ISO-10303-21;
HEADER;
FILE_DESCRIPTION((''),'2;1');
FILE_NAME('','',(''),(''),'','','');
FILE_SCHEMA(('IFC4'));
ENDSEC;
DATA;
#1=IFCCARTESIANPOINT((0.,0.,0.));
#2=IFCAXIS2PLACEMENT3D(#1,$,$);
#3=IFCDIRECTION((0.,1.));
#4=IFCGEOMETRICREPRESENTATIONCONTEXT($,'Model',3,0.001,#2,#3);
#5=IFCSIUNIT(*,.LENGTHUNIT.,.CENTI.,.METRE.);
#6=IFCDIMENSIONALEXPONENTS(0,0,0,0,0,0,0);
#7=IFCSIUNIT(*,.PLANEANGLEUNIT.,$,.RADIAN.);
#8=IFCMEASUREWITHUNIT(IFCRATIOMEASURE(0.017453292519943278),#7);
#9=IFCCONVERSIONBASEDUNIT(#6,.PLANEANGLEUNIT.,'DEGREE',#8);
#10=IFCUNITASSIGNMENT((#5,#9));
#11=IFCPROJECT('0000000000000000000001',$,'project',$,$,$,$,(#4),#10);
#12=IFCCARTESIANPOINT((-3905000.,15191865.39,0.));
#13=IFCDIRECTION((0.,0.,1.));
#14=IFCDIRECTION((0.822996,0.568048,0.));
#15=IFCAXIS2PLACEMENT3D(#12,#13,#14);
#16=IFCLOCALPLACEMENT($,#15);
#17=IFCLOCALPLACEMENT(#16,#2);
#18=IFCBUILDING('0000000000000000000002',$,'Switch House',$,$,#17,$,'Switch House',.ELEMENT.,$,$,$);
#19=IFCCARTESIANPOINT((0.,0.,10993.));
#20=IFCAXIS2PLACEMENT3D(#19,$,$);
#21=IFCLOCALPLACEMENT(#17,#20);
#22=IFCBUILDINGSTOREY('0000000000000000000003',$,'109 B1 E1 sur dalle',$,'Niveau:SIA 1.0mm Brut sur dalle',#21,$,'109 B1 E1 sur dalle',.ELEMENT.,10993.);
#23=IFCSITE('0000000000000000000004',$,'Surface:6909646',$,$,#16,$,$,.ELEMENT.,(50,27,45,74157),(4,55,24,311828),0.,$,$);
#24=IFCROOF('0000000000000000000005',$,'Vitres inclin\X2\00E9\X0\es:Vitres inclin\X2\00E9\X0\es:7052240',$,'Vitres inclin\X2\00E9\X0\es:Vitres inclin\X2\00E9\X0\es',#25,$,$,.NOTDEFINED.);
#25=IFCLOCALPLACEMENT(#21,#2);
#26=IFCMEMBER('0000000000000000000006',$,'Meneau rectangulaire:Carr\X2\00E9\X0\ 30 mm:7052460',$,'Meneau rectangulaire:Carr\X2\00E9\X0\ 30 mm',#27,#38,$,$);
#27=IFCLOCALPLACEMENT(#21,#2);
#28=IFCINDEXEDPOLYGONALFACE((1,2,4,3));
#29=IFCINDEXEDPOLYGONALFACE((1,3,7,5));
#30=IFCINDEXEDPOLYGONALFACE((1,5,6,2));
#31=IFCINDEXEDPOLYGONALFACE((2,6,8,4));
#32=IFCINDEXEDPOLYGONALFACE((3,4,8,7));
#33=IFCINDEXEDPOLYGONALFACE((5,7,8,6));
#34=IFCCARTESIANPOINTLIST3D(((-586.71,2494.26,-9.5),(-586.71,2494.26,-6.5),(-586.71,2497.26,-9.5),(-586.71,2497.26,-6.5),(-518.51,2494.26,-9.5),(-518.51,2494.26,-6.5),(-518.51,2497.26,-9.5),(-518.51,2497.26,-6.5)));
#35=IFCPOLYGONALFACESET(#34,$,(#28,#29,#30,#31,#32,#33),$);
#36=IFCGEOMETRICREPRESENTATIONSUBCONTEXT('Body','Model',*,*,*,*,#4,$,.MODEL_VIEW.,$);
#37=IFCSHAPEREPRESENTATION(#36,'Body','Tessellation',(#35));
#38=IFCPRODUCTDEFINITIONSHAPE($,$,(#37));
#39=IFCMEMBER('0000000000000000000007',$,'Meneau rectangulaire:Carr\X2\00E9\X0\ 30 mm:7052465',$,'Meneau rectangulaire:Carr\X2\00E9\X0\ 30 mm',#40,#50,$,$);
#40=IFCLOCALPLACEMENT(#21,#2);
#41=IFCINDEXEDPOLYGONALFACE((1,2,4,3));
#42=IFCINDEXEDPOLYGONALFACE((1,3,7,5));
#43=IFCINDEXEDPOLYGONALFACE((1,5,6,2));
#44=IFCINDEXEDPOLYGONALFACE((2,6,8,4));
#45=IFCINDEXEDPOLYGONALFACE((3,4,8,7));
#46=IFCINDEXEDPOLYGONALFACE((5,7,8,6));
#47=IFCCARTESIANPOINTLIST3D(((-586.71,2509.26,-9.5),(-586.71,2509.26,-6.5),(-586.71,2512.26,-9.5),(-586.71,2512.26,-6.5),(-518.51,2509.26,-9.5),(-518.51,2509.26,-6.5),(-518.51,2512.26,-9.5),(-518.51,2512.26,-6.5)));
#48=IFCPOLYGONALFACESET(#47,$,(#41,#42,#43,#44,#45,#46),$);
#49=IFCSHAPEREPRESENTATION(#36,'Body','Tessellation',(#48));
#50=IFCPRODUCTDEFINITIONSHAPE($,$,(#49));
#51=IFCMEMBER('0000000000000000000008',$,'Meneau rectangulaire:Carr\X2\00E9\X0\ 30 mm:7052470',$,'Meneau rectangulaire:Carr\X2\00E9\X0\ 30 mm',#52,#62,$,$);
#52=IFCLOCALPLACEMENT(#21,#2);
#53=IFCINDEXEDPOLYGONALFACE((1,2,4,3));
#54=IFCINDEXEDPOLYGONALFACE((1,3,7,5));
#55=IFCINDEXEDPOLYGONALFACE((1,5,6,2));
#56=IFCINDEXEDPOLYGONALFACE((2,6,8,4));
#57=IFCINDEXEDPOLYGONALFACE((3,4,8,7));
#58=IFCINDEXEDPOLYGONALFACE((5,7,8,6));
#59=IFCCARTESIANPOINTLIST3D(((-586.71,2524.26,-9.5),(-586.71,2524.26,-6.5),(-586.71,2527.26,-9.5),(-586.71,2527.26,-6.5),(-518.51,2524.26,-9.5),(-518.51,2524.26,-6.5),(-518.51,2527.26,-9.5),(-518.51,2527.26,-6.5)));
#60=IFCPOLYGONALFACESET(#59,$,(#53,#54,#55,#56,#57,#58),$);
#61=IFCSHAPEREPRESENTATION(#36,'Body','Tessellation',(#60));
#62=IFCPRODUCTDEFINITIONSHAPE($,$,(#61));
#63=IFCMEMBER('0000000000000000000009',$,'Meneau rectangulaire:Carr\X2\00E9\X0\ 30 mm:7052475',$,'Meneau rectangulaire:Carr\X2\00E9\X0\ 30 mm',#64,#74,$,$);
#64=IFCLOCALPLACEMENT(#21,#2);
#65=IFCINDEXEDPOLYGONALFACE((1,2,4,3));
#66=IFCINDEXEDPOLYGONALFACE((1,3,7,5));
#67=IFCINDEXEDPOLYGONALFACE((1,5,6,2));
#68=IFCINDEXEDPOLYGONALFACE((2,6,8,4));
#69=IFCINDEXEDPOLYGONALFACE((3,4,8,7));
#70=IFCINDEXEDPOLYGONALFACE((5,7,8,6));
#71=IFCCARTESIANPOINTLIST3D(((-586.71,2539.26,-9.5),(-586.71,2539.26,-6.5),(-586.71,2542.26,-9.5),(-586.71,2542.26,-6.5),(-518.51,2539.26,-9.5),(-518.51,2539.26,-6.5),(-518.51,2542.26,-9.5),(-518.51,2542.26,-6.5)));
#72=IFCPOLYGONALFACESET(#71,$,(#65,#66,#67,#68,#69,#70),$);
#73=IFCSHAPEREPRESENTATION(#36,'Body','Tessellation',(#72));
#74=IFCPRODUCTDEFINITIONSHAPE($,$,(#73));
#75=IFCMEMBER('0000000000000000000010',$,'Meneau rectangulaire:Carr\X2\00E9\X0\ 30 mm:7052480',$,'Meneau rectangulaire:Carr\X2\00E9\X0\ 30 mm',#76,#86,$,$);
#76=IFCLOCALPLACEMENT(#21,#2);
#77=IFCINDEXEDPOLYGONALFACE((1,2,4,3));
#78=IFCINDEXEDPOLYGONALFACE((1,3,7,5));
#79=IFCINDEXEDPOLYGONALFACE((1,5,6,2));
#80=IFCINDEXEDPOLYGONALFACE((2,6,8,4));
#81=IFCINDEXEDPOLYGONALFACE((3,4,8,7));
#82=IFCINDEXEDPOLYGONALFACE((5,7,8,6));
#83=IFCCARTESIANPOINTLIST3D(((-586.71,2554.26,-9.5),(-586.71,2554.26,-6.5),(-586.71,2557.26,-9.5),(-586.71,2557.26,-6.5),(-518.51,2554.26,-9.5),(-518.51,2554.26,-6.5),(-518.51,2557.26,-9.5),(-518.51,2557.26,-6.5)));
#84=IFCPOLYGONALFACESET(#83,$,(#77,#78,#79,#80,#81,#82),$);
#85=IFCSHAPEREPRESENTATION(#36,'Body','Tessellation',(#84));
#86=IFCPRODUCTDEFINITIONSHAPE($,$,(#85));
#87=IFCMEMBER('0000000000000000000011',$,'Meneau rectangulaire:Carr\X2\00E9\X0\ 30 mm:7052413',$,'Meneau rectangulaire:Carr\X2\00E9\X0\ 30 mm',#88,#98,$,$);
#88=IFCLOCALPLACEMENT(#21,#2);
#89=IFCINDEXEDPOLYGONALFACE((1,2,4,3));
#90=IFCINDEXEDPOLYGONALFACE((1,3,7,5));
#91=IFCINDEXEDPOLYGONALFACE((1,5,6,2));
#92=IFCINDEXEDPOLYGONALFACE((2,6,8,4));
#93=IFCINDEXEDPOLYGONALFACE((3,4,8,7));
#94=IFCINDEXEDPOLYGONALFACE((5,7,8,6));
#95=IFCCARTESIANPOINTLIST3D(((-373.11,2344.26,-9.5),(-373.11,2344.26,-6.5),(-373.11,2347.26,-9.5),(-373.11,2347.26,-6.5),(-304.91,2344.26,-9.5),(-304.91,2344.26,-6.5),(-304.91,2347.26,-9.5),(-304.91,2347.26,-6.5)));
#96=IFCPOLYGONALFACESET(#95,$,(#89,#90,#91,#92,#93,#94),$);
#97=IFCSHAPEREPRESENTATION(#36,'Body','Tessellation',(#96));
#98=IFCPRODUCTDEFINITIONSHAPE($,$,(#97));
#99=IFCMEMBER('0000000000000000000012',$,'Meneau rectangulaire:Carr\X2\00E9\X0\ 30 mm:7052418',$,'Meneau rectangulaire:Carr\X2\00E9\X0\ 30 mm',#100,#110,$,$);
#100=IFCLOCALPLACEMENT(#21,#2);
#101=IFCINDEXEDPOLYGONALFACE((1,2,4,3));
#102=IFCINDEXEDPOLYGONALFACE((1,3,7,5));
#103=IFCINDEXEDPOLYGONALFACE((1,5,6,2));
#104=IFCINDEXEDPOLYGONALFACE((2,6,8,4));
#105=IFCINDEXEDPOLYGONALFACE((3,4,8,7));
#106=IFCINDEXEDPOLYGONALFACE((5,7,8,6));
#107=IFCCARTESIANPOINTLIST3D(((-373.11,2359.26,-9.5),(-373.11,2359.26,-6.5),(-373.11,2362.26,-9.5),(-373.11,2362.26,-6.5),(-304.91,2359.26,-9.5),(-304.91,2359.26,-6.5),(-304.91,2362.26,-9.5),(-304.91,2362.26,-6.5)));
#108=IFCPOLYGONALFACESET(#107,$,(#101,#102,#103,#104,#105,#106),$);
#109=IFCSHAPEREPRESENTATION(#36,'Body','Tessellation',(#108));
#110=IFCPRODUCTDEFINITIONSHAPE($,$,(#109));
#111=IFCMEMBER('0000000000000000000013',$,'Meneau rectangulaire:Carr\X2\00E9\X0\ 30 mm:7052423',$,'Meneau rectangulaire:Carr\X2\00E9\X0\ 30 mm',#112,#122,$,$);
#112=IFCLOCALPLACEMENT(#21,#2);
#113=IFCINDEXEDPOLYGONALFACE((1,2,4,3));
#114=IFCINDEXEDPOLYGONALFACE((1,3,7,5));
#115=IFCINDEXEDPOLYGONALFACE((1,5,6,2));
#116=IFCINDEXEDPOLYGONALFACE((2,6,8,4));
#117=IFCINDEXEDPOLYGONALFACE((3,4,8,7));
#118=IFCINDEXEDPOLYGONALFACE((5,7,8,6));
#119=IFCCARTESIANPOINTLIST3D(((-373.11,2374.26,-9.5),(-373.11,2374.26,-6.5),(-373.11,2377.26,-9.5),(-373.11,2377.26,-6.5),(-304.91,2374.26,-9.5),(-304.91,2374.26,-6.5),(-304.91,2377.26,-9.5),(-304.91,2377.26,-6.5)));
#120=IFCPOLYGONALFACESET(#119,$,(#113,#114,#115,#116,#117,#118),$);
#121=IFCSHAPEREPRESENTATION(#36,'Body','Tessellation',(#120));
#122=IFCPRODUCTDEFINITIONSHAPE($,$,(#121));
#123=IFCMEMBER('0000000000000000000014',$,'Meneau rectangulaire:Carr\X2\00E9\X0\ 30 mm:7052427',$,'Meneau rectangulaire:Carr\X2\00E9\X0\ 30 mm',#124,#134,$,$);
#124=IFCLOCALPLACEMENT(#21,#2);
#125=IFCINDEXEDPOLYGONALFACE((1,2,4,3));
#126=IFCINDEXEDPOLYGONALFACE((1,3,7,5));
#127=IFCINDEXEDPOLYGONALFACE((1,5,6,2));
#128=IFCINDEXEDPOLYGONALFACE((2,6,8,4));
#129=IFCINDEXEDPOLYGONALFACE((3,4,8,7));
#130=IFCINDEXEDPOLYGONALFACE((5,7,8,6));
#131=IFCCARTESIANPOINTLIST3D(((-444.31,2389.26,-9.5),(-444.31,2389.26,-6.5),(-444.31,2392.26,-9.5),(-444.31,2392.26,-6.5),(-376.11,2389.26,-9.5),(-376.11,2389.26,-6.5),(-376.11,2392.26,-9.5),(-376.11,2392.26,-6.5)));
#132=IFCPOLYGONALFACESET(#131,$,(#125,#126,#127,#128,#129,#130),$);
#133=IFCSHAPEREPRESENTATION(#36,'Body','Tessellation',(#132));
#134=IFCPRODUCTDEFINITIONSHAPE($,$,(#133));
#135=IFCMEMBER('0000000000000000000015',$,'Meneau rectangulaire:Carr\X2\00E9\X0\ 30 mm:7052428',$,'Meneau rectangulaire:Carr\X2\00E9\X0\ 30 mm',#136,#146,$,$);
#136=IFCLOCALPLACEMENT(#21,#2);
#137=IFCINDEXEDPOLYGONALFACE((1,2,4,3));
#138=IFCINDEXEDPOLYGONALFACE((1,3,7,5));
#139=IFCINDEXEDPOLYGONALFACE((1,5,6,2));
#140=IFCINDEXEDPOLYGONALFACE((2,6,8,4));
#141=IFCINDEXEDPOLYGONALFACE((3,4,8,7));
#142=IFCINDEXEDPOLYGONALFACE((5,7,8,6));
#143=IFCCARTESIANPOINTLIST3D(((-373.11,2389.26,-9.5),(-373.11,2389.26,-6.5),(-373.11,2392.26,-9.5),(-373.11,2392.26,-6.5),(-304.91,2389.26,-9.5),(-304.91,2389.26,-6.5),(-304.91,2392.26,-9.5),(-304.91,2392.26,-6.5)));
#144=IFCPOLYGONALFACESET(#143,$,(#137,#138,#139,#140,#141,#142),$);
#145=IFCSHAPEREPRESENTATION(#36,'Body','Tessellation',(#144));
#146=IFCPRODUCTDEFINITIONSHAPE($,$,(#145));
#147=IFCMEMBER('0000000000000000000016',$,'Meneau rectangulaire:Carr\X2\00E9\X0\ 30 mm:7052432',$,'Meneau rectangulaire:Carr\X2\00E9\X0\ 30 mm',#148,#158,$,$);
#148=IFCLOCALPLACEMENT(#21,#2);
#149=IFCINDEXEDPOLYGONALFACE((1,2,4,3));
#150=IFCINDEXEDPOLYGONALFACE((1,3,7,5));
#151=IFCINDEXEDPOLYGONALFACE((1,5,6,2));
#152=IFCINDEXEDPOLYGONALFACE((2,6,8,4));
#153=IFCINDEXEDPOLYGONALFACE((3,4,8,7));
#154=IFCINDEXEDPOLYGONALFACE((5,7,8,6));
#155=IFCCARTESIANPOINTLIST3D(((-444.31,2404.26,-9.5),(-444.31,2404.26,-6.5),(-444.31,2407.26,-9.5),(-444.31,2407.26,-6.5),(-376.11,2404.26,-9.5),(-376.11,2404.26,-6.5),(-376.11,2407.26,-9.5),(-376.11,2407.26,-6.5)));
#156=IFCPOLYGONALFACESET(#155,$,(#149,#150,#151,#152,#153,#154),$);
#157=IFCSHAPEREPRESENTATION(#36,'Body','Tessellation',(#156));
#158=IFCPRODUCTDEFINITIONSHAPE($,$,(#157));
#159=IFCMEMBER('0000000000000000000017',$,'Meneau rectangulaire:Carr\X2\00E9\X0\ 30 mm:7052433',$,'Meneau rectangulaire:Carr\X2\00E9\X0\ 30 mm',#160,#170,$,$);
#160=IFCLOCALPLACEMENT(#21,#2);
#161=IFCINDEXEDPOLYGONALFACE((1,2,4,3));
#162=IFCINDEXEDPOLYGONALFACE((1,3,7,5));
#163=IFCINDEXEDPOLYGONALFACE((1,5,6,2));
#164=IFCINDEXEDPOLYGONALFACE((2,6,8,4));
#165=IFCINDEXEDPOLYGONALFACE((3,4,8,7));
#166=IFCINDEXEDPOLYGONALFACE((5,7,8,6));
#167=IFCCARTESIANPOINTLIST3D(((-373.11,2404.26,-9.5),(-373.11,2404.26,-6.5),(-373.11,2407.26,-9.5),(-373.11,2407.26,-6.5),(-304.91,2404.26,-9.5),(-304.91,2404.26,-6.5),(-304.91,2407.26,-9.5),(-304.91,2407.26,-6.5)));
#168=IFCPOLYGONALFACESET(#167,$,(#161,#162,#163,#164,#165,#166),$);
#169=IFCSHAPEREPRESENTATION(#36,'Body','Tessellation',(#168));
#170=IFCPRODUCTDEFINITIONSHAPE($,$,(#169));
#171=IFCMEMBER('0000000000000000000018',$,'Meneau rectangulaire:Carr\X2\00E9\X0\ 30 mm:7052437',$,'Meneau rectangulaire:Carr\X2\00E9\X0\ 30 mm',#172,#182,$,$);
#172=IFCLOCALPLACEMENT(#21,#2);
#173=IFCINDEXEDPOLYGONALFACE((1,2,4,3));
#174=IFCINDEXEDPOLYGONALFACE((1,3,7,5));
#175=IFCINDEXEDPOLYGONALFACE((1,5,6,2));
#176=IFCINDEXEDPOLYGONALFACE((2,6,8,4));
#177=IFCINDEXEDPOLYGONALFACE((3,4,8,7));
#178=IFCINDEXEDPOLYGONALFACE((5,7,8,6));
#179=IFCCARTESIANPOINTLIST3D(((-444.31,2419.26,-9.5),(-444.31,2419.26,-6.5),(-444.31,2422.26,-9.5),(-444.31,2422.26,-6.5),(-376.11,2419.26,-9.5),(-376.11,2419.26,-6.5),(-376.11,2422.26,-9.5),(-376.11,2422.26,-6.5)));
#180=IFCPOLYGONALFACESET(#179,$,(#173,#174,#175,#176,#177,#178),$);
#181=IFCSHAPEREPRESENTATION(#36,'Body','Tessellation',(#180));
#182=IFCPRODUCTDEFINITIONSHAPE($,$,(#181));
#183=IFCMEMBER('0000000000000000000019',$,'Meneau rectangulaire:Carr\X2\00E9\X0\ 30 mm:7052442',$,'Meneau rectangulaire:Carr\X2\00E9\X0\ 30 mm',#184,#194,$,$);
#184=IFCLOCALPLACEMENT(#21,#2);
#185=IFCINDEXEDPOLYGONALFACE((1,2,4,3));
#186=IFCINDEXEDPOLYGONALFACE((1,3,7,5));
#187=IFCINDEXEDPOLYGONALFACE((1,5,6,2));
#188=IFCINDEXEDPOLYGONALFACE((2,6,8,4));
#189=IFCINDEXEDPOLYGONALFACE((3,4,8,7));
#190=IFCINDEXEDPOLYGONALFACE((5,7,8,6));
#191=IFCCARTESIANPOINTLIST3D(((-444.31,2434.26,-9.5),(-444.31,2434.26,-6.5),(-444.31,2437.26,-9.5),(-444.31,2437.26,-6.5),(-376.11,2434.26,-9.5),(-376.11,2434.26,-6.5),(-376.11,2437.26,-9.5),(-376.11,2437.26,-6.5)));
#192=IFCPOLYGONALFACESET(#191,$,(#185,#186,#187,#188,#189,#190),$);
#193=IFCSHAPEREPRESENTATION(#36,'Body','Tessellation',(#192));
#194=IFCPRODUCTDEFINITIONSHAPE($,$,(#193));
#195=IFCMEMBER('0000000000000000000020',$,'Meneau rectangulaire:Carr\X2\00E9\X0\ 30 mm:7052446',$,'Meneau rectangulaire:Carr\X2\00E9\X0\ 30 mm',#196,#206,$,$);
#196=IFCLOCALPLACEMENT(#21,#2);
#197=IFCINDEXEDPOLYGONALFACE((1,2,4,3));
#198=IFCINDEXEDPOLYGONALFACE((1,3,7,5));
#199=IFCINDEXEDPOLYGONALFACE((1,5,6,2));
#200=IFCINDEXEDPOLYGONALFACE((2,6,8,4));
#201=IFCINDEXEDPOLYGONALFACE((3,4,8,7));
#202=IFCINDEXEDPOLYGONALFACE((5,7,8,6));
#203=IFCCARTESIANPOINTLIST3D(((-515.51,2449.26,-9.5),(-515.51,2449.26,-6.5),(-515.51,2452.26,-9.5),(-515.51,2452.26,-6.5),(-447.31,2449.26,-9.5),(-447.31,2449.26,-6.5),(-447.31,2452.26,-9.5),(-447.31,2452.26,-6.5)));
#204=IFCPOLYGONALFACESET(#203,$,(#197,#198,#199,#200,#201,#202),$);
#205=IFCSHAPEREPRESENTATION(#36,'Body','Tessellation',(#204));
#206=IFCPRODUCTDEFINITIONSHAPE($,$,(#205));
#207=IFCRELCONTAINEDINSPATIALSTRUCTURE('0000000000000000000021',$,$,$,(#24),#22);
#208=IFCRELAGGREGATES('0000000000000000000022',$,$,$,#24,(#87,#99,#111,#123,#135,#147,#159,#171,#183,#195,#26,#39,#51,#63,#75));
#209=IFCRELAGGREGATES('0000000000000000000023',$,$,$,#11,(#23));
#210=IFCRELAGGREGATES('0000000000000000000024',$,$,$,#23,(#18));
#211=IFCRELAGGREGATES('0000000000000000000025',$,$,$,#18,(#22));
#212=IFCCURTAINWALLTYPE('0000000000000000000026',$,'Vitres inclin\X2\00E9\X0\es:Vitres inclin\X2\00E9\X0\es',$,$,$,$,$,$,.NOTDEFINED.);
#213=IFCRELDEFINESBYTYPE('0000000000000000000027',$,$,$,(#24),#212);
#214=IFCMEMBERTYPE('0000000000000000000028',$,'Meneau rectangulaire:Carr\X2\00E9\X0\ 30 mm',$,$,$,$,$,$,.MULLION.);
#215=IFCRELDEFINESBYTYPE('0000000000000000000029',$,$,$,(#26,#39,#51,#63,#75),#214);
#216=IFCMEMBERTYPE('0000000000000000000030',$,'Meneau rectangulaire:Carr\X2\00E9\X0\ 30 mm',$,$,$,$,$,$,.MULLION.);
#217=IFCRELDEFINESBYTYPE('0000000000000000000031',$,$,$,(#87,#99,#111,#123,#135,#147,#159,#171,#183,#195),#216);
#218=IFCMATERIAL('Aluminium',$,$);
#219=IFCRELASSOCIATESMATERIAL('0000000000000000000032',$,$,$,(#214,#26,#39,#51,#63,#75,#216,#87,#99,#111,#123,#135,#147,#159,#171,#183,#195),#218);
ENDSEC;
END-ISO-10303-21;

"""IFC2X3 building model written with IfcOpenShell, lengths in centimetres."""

from ifc_helpers import new_model, entity, si_unit, converted_unit, direction, frame, origin, origin_2d_with_axis, place, context, subcontext, project, spatial, rectangle, extrude, source, transform, mapped, material, type_object, type_shapes, element, aggregate, save


model = new_model("IFC2X3")

# Units and contexts
model_context = context("Model", 3, precision=0.001, world=origin(), true_north=direction((0.0, 1.0)))
body_context = subcontext(model_context, "Body", "Model", "MODEL_VIEW")
ifc_project = project(units=[si_unit("LENGTHUNIT", "METRE", prefix="CENTI"), converted_unit("PLANEANGLEUNIT", "DEGREE", entity("IfcRatioMeasure", 0.017453292519943278), si_unit("PLANEANGLEUNIT", "RADIAN"), dimensions=[0, 0, 0, 0, 0, 0, 0])], contexts=[model_context])

# Site, building, storey
site_placement = place(None, frame((-3905000.0, 15191865.39, 0.0), z_axis=(0.0, 0.0, 1.0), x_axis=(0.822996, 0.568048, 0.0)))
site = spatial("IfcSite", under=ifc_project, at=site_placement, Name="Surface:6909646", CompositionType="ELEMENT", RefLatitude=(50, 27, 45, 74157), RefLongitude=(4, 55, 24, 311828), RefElevation=0.0)
building_placement = place(site_placement, origin())
building = spatial("IfcBuilding", under=site, at=building_placement, Name="Switch House", LongName="Switch House", CompositionType="ELEMENT")
storey_placement = place(building_placement, frame((0.0, 0.0, 10993.0)))
storey = spatial("IfcBuildingStorey", under=building, at=storey_placement, Name="109 B1 E1 sur dalle", ObjectType="Niveau:SIA 1.0mm Brut sur dalle", LongName="109 B1 E1 sur dalle", CompositionType="ELEMENT", Elevation=10993.0)

# Roof, members
curtain_wall_type = type_object("IfcCurtainWallType", Name="Vitres inclinées:Vitres inclinées", PredefinedType="NOTDEFINED")
roof_placement = place(storey_placement, frame((0.0, 0.0, -10993.0)))
roof = element("IfcRoof", 1, at=roof_placement, inside=storey, type_object=curtain_wall_type, Name="Vitres inclinées:Vitres inclinées:7052240", ObjectType="Vitres inclinées:Vitres inclinées", ShapeType="NOTDEFINED")
ifc_material = material(Name="Aluminium")
member_type_1 = type_object("IfcMemberType", Name="Meneau rectangulaire:Carré 30 mm", PredefinedType="MULLION", material=ifc_material)
shared_shape_1 = source(origin(), body_context, "Body", "SweptSolid", [
    extrude(rectangle(XDim=3.0, YDim=3.0, at=origin_2d_with_axis()), frame((0.0, 0.0, -68.2), z_axis=(0.0, 0.0, 1.0), x_axis=(0.0, -1.0, 0.0)), (0.0, 0.0, 1.0), 68.2),
])
type_shapes(member_type_1, [shared_shape_1])
member_1_placement = place(roof_placement, frame((-586.71, 2495.76, 10985.0), z_axis=(-1.0, 0.0, 0.0), x_axis=(0.0, 1.0, 0.0)))
member_1 = element("IfcMember", 2, at=member_1_placement, type_object=member_type_1, material=ifc_material, Name="Meneau rectangulaire:Carré 30 mm:7052460", ObjectType="Meneau rectangulaire:Carré 30 mm", context=body_context, shape_type="MappedRepresentation", body=[
    mapped(shared_shape_1, transform((0.0, 0.0, 0.0), scale=1.0)),
])
member_2_placement = place(roof_placement, frame((-586.71, 2510.76, 10985.0), z_axis=(-1.0, 0.0, 0.0), x_axis=(0.0, 1.0, 0.0)))
member_2 = element("IfcMember", 3, at=member_2_placement, type_object=member_type_1, material=ifc_material, Name="Meneau rectangulaire:Carré 30 mm:7052465", ObjectType="Meneau rectangulaire:Carré 30 mm", context=body_context, shape_type="MappedRepresentation", body=[
    mapped(shared_shape_1, transform((0.0, 0.0, 0.0), scale=1.0)),
])
member_3_placement = place(roof_placement, frame((-586.71, 2525.76, 10985.0), z_axis=(-1.0, 0.0, 0.0), x_axis=(0.0, 1.0, 0.0)))
member_3 = element("IfcMember", 4, at=member_3_placement, type_object=member_type_1, material=ifc_material, Name="Meneau rectangulaire:Carré 30 mm:7052470", ObjectType="Meneau rectangulaire:Carré 30 mm", context=body_context, shape_type="MappedRepresentation", body=[
    mapped(shared_shape_1, transform((0.0, 0.0, 0.0), scale=1.0)),
])
member_4_placement = place(roof_placement, frame((-586.71, 2540.76, 10985.0), z_axis=(-1.0, 0.0, 0.0), x_axis=(0.0, 1.0, 0.0)))
member_4 = element("IfcMember", 5, at=member_4_placement, type_object=member_type_1, material=ifc_material, Name="Meneau rectangulaire:Carré 30 mm:7052475", ObjectType="Meneau rectangulaire:Carré 30 mm", context=body_context, shape_type="MappedRepresentation", body=[
    mapped(shared_shape_1, transform((0.0, 0.0, 0.0), scale=1.0)),
])
member_5_placement = place(roof_placement, frame((-586.71, 2555.76, 10985.0), z_axis=(-1.0, 0.0, 0.0), x_axis=(0.0, 1.0, 0.0)))
member_5 = element("IfcMember", 6, at=member_5_placement, type_object=member_type_1, material=ifc_material, Name="Meneau rectangulaire:Carré 30 mm:7052480", ObjectType="Meneau rectangulaire:Carré 30 mm", context=body_context, shape_type="MappedRepresentation", body=[
    mapped(shared_shape_1, transform((0.0, 0.0, 0.0), scale=1.0)),
])
member_type_2 = type_object("IfcMemberType", Name="Meneau rectangulaire:Carré 30 mm", PredefinedType="MULLION", material=ifc_material)
shared_shape_2 = source(origin(), body_context, "Body", "SweptSolid", [
    extrude(rectangle(XDim=3.0, YDim=3.0, at=origin_2d_with_axis()), frame((0.0, 0.0, -68.2), z_axis=(0.0, 0.0, 1.0), x_axis=(0.0, -1.0, 0.0)), (0.0, 0.0, 1.0), 68.2),
])
type_shapes(member_type_2, [shared_shape_2])
member_6_placement = place(roof_placement, frame((-373.11, 2345.76, 10985.0), z_axis=(-1.0, 0.0, 0.0), x_axis=(0.0, 1.0, 0.0)))
member_6 = element("IfcMember", 7, at=member_6_placement, type_object=member_type_2, material=ifc_material, Name="Meneau rectangulaire:Carré 30 mm:7052413", ObjectType="Meneau rectangulaire:Carré 30 mm", context=body_context, shape_type="MappedRepresentation", body=[
    mapped(shared_shape_2, transform((0.0, 0.0, 0.0), scale=1.0)),
])
member_7_placement = place(roof_placement, frame((-373.11, 2360.76, 10985.0), z_axis=(-1.0, 0.0, 0.0), x_axis=(0.0, 1.0, 0.0)))
member_7 = element("IfcMember", 8, at=member_7_placement, type_object=member_type_2, material=ifc_material, Name="Meneau rectangulaire:Carré 30 mm:7052418", ObjectType="Meneau rectangulaire:Carré 30 mm", context=body_context, shape_type="MappedRepresentation", body=[
    mapped(shared_shape_2, transform((0.0, 0.0, 0.0), scale=1.0)),
])
member_8_placement = place(roof_placement, frame((-373.11, 2375.76, 10985.0), z_axis=(-1.0, 0.0, 0.0), x_axis=(0.0, 1.0, 0.0)))
member_8 = element("IfcMember", 9, at=member_8_placement, type_object=member_type_2, material=ifc_material, Name="Meneau rectangulaire:Carré 30 mm:7052423", ObjectType="Meneau rectangulaire:Carré 30 mm", context=body_context, shape_type="MappedRepresentation", body=[
    mapped(shared_shape_2, transform((0.0, 0.0, 0.0), scale=1.0)),
])
member_9_placement = place(roof_placement, frame((-444.31, 2390.76, 10985.0), z_axis=(-1.0, 0.0, 0.0), x_axis=(0.0, 1.0, 0.0)))
member_9 = element("IfcMember", 10, at=member_9_placement, type_object=member_type_2, material=ifc_material, Name="Meneau rectangulaire:Carré 30 mm:7052427", ObjectType="Meneau rectangulaire:Carré 30 mm", context=body_context, shape_type="MappedRepresentation", body=[
    mapped(shared_shape_2, transform((0.0, 0.0, 0.0), scale=1.0)),
])
member_10_placement = place(roof_placement, frame((-373.11, 2390.76, 10985.0), z_axis=(-1.0, 0.0, 0.0), x_axis=(0.0, 1.0, 0.0)))
member_10 = element("IfcMember", 11, at=member_10_placement, type_object=member_type_2, material=ifc_material, Name="Meneau rectangulaire:Carré 30 mm:7052428", ObjectType="Meneau rectangulaire:Carré 30 mm", context=body_context, shape_type="MappedRepresentation", body=[
    mapped(shared_shape_2, transform((0.0, 0.0, 0.0), scale=1.0)),
])
member_11_placement = place(roof_placement, frame((-444.31, 2405.76, 10985.0), z_axis=(-1.0, 0.0, 0.0), x_axis=(0.0, 1.0, 0.0)))
member_11 = element("IfcMember", 12, at=member_11_placement, type_object=member_type_2, material=ifc_material, Name="Meneau rectangulaire:Carré 30 mm:7052432", ObjectType="Meneau rectangulaire:Carré 30 mm", context=body_context, shape_type="MappedRepresentation", body=[
    mapped(shared_shape_2, transform((0.0, 0.0, 0.0), scale=1.0)),
])
member_12_placement = place(roof_placement, frame((-373.11, 2405.76, 10985.0), z_axis=(-1.0, 0.0, 0.0), x_axis=(0.0, 1.0, 0.0)))
member_12 = element("IfcMember", 13, at=member_12_placement, type_object=member_type_2, material=ifc_material, Name="Meneau rectangulaire:Carré 30 mm:7052433", ObjectType="Meneau rectangulaire:Carré 30 mm", context=body_context, shape_type="MappedRepresentation", body=[
    mapped(shared_shape_2, transform((0.0, 0.0, 0.0), scale=1.0)),
])
member_13_placement = place(roof_placement, frame((-444.31, 2420.76, 10985.0), z_axis=(-1.0, 0.0, 0.0), x_axis=(0.0, 1.0, 0.0)))
member_13 = element("IfcMember", 14, at=member_13_placement, type_object=member_type_2, material=ifc_material, Name="Meneau rectangulaire:Carré 30 mm:7052437", ObjectType="Meneau rectangulaire:Carré 30 mm", context=body_context, shape_type="MappedRepresentation", body=[
    mapped(shared_shape_2, transform((0.0, 0.0, 0.0), scale=1.0)),
])
member_14_placement = place(roof_placement, frame((-444.31, 2435.76, 10985.0), z_axis=(-1.0, 0.0, 0.0), x_axis=(0.0, 1.0, 0.0)))
member_14 = element("IfcMember", 15, at=member_14_placement, type_object=member_type_2, material=ifc_material, Name="Meneau rectangulaire:Carré 30 mm:7052442", ObjectType="Meneau rectangulaire:Carré 30 mm", context=body_context, shape_type="MappedRepresentation", body=[
    mapped(shared_shape_2, transform((0.0, 0.0, 0.0), scale=1.0)),
])
member_15_placement = place(roof_placement, frame((-515.51, 2450.76, 10985.0), z_axis=(-1.0, 0.0, 0.0), x_axis=(0.0, 1.0, 0.0)))
member_15 = element("IfcMember", 16, at=member_15_placement, type_object=member_type_2, material=ifc_material, Name="Meneau rectangulaire:Carré 30 mm:7052446", ObjectType="Meneau rectangulaire:Carré 30 mm", context=body_context, shape_type="MappedRepresentation", body=[
    mapped(shared_shape_2, transform((0.0, 0.0, 0.0), scale=1.0)),
])
aggregate(roof, [member_6, member_7, member_8, member_9, member_10, member_11, member_12, member_13, member_14, member_15, member_1, member_2, member_3, member_4, member_5])

save(model, "model.ifc")
